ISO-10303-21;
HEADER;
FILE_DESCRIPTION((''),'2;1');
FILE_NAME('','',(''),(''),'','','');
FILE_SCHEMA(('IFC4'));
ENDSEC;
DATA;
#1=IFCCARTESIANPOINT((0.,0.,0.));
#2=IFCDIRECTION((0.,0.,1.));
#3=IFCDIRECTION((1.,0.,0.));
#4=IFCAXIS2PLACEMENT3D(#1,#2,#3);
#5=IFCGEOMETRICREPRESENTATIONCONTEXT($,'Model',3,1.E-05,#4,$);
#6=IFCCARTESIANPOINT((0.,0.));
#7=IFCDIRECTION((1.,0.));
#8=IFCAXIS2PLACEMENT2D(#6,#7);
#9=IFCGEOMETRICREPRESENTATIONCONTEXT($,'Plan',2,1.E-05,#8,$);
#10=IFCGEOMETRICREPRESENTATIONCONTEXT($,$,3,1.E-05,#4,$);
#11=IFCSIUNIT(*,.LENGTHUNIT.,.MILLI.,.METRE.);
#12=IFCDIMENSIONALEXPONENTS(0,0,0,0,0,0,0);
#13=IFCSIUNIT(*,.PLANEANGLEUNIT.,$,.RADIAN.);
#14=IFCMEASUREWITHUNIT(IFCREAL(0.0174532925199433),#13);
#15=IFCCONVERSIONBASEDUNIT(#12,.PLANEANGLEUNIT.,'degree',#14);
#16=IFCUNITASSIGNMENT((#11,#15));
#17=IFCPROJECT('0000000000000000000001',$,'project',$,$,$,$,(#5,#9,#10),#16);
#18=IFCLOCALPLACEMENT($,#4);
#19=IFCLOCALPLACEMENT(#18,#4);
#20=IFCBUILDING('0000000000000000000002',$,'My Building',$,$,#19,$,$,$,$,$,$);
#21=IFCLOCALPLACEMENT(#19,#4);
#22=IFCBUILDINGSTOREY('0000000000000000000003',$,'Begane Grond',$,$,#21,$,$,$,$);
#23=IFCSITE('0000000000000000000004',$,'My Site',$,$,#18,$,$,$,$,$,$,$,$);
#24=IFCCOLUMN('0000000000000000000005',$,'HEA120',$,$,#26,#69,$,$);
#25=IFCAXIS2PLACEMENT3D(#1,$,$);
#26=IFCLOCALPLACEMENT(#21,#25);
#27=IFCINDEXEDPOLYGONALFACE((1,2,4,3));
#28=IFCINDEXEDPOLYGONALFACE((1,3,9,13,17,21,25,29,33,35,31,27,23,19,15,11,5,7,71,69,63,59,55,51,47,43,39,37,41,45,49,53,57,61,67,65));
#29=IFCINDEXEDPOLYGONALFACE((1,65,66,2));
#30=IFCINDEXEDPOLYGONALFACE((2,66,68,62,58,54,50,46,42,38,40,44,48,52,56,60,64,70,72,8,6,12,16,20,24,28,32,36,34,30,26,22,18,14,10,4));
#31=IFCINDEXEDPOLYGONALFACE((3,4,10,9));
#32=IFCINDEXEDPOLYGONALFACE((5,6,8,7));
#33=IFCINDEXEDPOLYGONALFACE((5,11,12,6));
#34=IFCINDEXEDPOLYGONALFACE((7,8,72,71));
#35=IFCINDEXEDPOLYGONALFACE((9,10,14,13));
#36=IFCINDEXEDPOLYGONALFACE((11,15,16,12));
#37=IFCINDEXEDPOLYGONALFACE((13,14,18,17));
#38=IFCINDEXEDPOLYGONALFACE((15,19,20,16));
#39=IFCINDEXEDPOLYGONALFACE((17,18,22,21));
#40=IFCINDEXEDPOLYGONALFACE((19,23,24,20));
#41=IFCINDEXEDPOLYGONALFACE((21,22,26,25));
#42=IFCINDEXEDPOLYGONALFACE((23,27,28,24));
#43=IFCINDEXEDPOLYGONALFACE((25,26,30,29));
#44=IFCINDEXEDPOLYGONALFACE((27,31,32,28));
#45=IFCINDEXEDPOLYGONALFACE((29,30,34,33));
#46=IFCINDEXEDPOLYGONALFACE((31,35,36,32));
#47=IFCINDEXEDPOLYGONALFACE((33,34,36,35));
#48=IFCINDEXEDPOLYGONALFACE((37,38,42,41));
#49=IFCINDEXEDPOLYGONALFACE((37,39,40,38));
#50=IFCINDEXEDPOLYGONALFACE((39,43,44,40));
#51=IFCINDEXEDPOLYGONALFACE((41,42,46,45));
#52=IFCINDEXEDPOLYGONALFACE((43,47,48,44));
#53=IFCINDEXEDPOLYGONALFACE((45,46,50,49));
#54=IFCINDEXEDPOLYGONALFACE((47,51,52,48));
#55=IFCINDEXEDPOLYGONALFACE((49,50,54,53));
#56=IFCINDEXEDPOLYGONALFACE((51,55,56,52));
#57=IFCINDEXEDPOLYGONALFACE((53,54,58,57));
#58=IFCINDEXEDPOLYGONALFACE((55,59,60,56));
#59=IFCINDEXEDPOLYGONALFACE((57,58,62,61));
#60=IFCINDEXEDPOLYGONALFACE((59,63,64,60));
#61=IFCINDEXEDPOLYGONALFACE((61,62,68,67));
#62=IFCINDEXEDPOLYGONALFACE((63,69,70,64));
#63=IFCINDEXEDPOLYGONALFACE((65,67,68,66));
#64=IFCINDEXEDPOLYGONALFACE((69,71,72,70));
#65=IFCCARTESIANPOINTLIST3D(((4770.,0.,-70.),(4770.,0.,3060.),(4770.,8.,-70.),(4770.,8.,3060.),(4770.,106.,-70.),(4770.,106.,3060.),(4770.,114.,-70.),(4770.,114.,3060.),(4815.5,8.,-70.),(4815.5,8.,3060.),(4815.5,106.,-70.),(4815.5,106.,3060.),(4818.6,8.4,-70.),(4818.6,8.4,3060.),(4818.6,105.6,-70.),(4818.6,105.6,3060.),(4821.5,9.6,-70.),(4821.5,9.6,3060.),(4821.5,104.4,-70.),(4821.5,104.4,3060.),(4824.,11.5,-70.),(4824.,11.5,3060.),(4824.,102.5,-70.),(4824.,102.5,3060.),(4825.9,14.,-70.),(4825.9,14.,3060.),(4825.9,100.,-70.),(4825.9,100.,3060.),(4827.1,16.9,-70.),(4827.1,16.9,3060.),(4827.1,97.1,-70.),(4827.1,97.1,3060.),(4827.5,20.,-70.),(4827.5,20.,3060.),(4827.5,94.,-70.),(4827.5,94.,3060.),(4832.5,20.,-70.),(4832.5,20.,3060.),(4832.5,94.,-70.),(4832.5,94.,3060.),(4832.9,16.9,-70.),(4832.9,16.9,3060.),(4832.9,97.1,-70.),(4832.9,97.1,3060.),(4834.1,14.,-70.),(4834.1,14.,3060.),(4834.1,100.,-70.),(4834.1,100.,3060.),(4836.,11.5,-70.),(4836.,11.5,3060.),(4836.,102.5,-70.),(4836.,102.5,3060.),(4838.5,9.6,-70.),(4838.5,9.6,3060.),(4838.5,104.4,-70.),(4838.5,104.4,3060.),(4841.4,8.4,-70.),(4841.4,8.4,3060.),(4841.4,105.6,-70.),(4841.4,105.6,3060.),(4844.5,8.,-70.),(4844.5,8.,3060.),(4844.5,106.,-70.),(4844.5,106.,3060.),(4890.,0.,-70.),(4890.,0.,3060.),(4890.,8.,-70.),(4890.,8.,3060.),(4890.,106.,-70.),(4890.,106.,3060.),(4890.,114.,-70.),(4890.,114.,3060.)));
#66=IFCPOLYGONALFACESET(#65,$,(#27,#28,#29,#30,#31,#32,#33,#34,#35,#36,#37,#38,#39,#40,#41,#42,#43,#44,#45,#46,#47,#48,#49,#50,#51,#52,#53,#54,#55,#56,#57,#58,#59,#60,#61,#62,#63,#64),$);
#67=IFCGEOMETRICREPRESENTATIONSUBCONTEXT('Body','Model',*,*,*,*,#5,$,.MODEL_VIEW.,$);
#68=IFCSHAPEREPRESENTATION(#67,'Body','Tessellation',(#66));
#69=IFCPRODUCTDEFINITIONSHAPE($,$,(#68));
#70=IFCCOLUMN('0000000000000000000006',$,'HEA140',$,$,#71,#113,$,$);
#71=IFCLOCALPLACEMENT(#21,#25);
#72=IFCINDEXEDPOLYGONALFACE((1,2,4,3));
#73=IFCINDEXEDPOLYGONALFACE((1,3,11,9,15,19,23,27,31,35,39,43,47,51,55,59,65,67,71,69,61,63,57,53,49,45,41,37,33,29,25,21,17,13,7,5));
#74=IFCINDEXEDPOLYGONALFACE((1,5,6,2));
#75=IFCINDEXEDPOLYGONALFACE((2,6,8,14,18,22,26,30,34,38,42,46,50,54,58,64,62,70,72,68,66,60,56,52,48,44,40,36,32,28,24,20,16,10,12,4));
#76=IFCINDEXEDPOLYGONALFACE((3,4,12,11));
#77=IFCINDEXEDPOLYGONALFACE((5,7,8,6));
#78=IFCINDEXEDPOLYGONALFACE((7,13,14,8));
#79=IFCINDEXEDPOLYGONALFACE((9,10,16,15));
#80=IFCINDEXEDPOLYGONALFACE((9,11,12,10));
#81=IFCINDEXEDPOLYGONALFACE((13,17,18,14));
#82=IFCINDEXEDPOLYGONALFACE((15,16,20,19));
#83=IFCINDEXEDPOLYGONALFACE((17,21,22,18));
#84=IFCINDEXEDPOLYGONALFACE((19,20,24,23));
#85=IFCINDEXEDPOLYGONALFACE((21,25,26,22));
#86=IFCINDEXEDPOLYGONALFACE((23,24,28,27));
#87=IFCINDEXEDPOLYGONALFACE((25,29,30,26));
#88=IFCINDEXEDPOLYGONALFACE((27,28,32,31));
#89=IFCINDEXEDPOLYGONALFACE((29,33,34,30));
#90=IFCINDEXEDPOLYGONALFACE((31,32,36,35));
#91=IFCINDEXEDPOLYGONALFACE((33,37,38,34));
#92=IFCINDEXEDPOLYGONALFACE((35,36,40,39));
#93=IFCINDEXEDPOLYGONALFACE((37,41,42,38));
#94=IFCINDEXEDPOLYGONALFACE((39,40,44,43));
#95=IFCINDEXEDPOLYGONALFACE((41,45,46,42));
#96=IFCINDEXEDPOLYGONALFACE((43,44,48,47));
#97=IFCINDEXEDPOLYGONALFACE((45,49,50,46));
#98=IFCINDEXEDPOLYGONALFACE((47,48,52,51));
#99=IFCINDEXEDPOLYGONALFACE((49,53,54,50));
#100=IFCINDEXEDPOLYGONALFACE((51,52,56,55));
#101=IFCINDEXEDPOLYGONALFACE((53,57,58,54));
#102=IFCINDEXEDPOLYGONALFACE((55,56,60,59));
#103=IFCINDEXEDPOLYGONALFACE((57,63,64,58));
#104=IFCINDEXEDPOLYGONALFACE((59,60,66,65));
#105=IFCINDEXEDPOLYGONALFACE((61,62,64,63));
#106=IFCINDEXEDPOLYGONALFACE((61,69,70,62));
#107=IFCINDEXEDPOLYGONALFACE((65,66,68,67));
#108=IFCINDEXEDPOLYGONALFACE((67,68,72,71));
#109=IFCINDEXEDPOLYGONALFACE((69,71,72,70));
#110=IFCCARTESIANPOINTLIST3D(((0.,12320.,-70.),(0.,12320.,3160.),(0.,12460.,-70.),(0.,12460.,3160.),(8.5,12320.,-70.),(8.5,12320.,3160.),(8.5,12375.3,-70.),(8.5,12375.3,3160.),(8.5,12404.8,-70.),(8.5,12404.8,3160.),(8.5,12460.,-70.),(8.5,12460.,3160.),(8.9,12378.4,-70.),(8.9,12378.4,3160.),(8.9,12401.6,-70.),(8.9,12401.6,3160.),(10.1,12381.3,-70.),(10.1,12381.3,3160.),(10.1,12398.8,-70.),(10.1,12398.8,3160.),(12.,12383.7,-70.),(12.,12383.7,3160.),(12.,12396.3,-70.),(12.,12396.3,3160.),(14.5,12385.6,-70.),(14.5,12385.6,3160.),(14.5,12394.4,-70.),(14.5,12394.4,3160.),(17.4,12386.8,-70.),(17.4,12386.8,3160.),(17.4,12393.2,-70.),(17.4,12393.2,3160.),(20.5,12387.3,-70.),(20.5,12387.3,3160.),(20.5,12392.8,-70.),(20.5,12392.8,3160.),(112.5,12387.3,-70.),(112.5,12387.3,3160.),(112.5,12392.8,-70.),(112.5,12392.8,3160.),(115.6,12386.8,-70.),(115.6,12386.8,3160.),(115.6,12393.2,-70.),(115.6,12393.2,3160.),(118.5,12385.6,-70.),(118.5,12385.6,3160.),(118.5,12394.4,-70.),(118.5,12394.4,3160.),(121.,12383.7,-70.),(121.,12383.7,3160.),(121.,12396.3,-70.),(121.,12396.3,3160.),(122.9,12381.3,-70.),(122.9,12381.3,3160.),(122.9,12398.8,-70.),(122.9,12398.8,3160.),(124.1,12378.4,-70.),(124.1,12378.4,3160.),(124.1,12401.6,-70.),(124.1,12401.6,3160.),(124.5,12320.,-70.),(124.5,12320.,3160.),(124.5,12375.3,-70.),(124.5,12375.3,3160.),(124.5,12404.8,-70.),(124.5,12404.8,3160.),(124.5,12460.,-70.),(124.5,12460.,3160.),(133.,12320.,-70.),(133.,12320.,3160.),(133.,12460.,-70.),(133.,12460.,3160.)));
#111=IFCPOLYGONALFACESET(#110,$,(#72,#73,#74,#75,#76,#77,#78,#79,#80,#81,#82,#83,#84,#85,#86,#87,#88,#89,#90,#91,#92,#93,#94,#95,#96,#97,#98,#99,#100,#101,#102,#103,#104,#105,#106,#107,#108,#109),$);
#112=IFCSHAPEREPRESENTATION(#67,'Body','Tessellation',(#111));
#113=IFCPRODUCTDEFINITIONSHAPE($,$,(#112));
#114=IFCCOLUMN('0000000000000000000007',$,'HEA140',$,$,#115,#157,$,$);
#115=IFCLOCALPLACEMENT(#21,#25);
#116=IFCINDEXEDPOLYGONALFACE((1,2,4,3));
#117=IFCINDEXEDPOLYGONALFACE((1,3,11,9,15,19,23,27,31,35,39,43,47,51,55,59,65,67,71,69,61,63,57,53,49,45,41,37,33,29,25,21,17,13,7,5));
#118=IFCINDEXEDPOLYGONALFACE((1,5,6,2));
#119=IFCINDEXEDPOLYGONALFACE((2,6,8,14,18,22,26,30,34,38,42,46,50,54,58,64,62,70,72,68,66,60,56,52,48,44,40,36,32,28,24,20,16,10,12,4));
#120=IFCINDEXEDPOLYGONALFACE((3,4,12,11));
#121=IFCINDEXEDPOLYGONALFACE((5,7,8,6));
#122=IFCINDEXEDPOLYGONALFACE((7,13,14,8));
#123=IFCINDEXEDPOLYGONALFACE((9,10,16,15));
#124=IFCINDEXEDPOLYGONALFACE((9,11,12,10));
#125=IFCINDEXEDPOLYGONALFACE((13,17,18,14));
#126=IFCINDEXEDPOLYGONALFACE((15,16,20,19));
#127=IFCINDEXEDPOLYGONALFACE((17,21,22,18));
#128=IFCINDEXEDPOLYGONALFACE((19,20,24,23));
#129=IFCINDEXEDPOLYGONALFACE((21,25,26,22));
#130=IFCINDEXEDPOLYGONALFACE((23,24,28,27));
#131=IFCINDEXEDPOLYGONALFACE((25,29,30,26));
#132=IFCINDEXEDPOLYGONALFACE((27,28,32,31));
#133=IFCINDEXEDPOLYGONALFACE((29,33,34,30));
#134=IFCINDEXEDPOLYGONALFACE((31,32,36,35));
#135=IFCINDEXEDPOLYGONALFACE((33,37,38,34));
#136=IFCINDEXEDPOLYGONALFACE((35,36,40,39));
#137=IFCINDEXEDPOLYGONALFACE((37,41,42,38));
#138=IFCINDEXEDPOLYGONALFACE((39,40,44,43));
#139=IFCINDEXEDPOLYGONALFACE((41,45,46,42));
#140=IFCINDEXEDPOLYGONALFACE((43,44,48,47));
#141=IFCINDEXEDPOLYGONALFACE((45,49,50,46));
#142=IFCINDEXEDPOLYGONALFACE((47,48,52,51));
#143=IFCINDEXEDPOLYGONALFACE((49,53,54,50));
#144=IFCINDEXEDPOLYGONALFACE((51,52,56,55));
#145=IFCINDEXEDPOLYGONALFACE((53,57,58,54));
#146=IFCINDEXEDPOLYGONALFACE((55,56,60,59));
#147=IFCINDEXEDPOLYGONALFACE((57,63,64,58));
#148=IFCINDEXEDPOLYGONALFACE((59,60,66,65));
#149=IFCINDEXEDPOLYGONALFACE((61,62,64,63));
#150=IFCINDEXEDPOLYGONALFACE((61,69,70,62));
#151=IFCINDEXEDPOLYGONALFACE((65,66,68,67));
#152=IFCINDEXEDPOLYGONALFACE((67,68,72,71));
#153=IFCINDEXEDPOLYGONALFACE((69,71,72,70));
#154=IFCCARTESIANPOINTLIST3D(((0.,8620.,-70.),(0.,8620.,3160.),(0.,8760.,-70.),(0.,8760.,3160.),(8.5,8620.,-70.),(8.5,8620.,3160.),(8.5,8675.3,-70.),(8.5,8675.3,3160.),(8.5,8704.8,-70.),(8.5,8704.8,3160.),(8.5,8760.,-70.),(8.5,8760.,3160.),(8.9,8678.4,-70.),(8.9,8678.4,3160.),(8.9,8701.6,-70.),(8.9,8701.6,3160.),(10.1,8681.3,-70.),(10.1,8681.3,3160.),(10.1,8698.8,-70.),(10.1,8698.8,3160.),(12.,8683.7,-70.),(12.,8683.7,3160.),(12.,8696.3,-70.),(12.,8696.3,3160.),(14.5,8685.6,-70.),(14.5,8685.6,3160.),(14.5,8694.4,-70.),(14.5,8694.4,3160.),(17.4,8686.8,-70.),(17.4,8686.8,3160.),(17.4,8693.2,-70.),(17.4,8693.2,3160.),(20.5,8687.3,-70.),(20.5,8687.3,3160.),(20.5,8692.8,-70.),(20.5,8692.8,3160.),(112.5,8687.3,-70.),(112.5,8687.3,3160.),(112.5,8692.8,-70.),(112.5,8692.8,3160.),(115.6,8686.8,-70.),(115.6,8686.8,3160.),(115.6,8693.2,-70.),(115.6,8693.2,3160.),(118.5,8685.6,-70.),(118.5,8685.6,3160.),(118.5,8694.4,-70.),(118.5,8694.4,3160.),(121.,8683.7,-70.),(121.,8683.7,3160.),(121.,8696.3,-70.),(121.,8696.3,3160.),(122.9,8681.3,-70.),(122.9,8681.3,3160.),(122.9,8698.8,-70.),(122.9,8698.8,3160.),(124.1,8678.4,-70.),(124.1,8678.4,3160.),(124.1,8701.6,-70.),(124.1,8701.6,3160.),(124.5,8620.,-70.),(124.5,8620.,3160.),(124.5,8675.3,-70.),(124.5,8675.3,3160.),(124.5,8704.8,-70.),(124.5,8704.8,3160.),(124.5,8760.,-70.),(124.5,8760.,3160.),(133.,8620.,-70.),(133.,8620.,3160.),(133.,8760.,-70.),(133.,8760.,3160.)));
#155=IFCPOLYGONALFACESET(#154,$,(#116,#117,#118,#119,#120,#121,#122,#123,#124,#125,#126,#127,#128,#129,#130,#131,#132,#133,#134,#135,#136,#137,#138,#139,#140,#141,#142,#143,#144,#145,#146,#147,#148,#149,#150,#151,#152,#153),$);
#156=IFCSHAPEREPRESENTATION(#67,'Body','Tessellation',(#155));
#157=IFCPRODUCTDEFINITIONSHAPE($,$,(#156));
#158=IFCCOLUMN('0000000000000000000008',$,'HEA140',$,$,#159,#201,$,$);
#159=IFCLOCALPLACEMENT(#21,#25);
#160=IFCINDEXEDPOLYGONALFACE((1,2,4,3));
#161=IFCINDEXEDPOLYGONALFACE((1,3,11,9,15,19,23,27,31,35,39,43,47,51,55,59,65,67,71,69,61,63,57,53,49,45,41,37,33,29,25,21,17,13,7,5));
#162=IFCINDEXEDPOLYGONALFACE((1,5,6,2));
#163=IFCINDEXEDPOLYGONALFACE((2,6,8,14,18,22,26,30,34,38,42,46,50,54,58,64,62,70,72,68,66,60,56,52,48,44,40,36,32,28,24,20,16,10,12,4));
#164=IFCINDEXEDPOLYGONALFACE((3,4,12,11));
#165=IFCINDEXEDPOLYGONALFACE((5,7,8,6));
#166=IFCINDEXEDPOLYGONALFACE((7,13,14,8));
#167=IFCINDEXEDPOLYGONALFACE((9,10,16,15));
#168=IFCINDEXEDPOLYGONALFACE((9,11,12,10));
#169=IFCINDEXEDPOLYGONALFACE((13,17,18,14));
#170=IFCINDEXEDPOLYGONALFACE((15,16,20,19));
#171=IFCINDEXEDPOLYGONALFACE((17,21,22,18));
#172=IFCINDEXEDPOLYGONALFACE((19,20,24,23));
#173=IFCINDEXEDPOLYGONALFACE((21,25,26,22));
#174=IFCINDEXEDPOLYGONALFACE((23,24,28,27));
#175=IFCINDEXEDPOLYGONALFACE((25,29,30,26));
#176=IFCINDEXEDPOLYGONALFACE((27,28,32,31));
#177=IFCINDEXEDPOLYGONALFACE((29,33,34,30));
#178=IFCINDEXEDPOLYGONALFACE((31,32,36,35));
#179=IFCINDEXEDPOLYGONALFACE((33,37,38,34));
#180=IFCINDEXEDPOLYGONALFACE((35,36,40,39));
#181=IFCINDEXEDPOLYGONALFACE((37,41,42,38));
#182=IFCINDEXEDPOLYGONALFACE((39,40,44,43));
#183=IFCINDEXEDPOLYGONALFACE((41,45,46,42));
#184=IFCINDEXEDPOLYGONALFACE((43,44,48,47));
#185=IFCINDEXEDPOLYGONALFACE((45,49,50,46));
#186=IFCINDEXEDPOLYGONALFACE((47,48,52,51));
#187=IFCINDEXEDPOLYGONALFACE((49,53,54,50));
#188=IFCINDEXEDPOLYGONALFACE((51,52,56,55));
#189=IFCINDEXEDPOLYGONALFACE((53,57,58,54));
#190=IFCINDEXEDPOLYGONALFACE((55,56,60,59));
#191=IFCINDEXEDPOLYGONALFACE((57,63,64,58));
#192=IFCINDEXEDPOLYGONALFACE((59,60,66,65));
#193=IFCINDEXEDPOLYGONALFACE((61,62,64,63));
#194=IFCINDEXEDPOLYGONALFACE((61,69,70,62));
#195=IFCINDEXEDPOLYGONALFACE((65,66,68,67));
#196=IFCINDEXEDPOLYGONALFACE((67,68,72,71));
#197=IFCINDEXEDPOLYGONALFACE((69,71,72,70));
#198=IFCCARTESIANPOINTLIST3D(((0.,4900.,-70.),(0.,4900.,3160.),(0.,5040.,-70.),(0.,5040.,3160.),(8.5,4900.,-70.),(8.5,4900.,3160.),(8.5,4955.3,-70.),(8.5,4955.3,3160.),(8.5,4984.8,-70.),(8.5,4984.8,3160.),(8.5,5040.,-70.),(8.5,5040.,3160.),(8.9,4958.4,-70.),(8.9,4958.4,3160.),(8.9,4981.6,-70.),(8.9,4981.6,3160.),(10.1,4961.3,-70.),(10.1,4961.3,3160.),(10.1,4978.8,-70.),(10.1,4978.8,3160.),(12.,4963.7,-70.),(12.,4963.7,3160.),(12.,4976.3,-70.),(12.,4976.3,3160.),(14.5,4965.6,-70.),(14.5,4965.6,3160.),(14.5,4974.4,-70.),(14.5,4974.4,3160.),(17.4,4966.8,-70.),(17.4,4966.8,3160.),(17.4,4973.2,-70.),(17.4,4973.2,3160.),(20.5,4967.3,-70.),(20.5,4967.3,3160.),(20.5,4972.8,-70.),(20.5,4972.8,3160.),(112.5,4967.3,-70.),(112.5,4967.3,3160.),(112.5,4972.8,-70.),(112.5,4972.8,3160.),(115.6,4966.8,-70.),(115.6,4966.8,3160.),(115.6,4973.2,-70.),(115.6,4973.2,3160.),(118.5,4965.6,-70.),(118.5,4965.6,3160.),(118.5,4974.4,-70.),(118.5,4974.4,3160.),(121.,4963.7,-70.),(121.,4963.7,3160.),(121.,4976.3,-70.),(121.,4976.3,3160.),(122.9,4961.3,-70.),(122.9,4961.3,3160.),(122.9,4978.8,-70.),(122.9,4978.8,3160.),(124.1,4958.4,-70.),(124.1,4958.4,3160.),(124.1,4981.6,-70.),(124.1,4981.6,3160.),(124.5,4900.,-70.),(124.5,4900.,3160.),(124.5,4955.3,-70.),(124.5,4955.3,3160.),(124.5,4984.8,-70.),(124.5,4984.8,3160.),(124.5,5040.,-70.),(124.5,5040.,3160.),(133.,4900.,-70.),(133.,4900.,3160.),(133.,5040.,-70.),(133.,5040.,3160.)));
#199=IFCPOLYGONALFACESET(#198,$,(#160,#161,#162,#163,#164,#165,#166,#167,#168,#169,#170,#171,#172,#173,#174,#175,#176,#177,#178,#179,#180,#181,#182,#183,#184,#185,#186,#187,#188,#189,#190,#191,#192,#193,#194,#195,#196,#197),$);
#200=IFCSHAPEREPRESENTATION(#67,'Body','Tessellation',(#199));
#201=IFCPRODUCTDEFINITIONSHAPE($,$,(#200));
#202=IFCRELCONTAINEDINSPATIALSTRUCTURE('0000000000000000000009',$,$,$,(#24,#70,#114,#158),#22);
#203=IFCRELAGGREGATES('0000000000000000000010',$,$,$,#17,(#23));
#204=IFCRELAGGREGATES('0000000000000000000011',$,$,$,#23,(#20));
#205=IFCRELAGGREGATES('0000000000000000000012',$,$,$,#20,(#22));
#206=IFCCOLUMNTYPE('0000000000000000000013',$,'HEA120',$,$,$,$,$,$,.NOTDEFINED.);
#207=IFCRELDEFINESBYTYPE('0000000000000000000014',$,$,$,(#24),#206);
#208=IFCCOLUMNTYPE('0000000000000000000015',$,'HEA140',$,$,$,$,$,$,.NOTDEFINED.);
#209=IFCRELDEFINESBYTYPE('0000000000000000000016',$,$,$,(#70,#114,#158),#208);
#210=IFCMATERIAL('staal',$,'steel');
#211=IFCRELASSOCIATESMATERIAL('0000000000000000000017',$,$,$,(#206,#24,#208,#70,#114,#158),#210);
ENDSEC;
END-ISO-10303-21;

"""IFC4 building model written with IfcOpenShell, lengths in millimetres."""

from ifc_helpers import new_model, entity, si_unit, converted_unit, frame, origin_with_axes, origin_2d_with_axis, place, context, subcontext, project, spatial, i_section, extrude, material, material_profile, profile_set, profile_usage, type_object, element, save


model = new_model("IFC4")

# Units and contexts
model_context = context("Model", 3, precision=1e-05, world=origin_with_axes())
plan_context = context("Plan", 2, precision=1e-05, world=origin_2d_with_axis())
context_of_model = context(None, 3, precision=1e-05, world=origin_with_axes())
body_context = subcontext(model_context, "Body", "Model", "MODEL_VIEW")
ifc_project = project(units=[si_unit("LENGTHUNIT", "METRE", prefix="MILLI"), converted_unit("PLANEANGLEUNIT", "degree", entity("IfcReal", 0.0174532925199433), si_unit("PLANEANGLEUNIT", "RADIAN"), dimensions=[0, 0, 0, 0, 0, 0, 0])], contexts=[model_context, plan_context, context_of_model])

# Site, building, storey
site_placement = place(None, origin_with_axes())
site = spatial("IfcSite", under=ifc_project, at=site_placement, Name="My Site")
building_placement = place(site_placement, origin_with_axes())
building = spatial("IfcBuilding", under=site, at=building_placement, Name="My Building")
storey_placement = place(building_placement, origin_with_axes())
storey = spatial("IfcBuildingStorey", under=building, at=storey_placement, Name="Begane Grond")

# Columns
ifc_material = material(Name="staal", Category="steel")
ifc_material_profile_1 = material_profile(ifc_material, i_section(OverallWidth=120.0, OverallDepth=114.0, WebThickness=5.0, FlangeThickness=8.0, FilletRadius=12.0))
ifc_profile_set_1 = profile_set([ifc_material_profile_1], Name="HEA120")
column_type_1 = type_object("IfcColumnType", Name="HEA120", PredefinedType="NOTDEFINED", material=ifc_profile_set_1)
ifc_profile_usage_1 = profile_usage(ifc_profile_set_1)
column_1_placement = place(storey_placement, frame((4830.0, 57.0, -70.0), z_axis=(0.0, 0.0, 1.0), x_axis=(-1.0, 0.0, 0.0)))
element("IfcColumn", 1, at=column_1_placement, inside=storey, type_object=column_type_1, material=ifc_profile_usage_1, Name="HEA120", context=body_context, shape_type="SweptSolid", body=[
    extrude(i_section(OverallWidth=120.0, OverallDepth=114.0, WebThickness=5.0, FlangeThickness=8.0, FilletRadius=12.0), origin_with_axes(), (0.0, 0.0, 1.0), 3130.0),
])
ifc_material_profile_2 = material_profile(ifc_material, i_section(OverallWidth=140.0, OverallDepth=133.0, WebThickness=5.5, FlangeThickness=8.5, FilletRadius=12.0))
ifc_profile_set_2 = profile_set([ifc_material_profile_2], Name="HEA140")
ifc_profile_usage_2 = profile_usage(ifc_profile_set_2)
column_type_2 = type_object("IfcColumnType", Name="HEA140", PredefinedType="NOTDEFINED", material=ifc_profile_set_2)
column_2_placement = place(storey_placement, frame((66.5, 12390.0, -70.0), z_axis=(0.0, 0.0, 1.0), x_axis=(0.0, 1.0, 0.0)))
element("IfcColumn", 2, at=column_2_placement, inside=storey, type_object=column_type_2, material=ifc_profile_usage_2, Name="HEA140", context=body_context, shape_type="SweptSolid", body=[
    extrude(i_section(OverallWidth=140.0, OverallDepth=133.0, WebThickness=5.5, FlangeThickness=8.5, FilletRadius=12.0), origin_with_axes(), (0.0, 0.0, 1.0), 3230.0),
])
ifc_profile_usage_3 = profile_usage(ifc_profile_set_2)
column_3_placement = place(storey_placement, frame((66.5, 8690.0, -70.0), z_axis=(0.0, 0.0, 1.0), x_axis=(0.0, 1.0, 0.0)))
element("IfcColumn", 3, at=column_3_placement, inside=storey, type_object=column_type_2, material=ifc_profile_usage_3, Name="HEA140", context=body_context, shape_type="SweptSolid", body=[
    extrude(i_section(OverallWidth=140.0, OverallDepth=133.0, WebThickness=5.5, FlangeThickness=8.5, FilletRadius=12.0), origin_with_axes(), (0.0, 0.0, 1.0), 3230.0),
])
ifc_profile_usage_4 = profile_usage(ifc_profile_set_2)
column_4_placement = place(storey_placement, frame((66.5, 4970.0, -70.0), z_axis=(0.0, 0.0, 1.0), x_axis=(0.0, 1.0, 0.0)))
element("IfcColumn", 4, at=column_4_placement, inside=storey, type_object=column_type_2, material=ifc_profile_usage_4, Name="HEA140", context=body_context, shape_type="SweptSolid", body=[
    extrude(i_section(OverallWidth=140.0, OverallDepth=133.0, WebThickness=5.5, FlangeThickness=8.5, FilletRadius=12.0), origin_with_axes(), (0.0, 0.0, 1.0), 3230.0),
])

save(model, "model.ifc")
